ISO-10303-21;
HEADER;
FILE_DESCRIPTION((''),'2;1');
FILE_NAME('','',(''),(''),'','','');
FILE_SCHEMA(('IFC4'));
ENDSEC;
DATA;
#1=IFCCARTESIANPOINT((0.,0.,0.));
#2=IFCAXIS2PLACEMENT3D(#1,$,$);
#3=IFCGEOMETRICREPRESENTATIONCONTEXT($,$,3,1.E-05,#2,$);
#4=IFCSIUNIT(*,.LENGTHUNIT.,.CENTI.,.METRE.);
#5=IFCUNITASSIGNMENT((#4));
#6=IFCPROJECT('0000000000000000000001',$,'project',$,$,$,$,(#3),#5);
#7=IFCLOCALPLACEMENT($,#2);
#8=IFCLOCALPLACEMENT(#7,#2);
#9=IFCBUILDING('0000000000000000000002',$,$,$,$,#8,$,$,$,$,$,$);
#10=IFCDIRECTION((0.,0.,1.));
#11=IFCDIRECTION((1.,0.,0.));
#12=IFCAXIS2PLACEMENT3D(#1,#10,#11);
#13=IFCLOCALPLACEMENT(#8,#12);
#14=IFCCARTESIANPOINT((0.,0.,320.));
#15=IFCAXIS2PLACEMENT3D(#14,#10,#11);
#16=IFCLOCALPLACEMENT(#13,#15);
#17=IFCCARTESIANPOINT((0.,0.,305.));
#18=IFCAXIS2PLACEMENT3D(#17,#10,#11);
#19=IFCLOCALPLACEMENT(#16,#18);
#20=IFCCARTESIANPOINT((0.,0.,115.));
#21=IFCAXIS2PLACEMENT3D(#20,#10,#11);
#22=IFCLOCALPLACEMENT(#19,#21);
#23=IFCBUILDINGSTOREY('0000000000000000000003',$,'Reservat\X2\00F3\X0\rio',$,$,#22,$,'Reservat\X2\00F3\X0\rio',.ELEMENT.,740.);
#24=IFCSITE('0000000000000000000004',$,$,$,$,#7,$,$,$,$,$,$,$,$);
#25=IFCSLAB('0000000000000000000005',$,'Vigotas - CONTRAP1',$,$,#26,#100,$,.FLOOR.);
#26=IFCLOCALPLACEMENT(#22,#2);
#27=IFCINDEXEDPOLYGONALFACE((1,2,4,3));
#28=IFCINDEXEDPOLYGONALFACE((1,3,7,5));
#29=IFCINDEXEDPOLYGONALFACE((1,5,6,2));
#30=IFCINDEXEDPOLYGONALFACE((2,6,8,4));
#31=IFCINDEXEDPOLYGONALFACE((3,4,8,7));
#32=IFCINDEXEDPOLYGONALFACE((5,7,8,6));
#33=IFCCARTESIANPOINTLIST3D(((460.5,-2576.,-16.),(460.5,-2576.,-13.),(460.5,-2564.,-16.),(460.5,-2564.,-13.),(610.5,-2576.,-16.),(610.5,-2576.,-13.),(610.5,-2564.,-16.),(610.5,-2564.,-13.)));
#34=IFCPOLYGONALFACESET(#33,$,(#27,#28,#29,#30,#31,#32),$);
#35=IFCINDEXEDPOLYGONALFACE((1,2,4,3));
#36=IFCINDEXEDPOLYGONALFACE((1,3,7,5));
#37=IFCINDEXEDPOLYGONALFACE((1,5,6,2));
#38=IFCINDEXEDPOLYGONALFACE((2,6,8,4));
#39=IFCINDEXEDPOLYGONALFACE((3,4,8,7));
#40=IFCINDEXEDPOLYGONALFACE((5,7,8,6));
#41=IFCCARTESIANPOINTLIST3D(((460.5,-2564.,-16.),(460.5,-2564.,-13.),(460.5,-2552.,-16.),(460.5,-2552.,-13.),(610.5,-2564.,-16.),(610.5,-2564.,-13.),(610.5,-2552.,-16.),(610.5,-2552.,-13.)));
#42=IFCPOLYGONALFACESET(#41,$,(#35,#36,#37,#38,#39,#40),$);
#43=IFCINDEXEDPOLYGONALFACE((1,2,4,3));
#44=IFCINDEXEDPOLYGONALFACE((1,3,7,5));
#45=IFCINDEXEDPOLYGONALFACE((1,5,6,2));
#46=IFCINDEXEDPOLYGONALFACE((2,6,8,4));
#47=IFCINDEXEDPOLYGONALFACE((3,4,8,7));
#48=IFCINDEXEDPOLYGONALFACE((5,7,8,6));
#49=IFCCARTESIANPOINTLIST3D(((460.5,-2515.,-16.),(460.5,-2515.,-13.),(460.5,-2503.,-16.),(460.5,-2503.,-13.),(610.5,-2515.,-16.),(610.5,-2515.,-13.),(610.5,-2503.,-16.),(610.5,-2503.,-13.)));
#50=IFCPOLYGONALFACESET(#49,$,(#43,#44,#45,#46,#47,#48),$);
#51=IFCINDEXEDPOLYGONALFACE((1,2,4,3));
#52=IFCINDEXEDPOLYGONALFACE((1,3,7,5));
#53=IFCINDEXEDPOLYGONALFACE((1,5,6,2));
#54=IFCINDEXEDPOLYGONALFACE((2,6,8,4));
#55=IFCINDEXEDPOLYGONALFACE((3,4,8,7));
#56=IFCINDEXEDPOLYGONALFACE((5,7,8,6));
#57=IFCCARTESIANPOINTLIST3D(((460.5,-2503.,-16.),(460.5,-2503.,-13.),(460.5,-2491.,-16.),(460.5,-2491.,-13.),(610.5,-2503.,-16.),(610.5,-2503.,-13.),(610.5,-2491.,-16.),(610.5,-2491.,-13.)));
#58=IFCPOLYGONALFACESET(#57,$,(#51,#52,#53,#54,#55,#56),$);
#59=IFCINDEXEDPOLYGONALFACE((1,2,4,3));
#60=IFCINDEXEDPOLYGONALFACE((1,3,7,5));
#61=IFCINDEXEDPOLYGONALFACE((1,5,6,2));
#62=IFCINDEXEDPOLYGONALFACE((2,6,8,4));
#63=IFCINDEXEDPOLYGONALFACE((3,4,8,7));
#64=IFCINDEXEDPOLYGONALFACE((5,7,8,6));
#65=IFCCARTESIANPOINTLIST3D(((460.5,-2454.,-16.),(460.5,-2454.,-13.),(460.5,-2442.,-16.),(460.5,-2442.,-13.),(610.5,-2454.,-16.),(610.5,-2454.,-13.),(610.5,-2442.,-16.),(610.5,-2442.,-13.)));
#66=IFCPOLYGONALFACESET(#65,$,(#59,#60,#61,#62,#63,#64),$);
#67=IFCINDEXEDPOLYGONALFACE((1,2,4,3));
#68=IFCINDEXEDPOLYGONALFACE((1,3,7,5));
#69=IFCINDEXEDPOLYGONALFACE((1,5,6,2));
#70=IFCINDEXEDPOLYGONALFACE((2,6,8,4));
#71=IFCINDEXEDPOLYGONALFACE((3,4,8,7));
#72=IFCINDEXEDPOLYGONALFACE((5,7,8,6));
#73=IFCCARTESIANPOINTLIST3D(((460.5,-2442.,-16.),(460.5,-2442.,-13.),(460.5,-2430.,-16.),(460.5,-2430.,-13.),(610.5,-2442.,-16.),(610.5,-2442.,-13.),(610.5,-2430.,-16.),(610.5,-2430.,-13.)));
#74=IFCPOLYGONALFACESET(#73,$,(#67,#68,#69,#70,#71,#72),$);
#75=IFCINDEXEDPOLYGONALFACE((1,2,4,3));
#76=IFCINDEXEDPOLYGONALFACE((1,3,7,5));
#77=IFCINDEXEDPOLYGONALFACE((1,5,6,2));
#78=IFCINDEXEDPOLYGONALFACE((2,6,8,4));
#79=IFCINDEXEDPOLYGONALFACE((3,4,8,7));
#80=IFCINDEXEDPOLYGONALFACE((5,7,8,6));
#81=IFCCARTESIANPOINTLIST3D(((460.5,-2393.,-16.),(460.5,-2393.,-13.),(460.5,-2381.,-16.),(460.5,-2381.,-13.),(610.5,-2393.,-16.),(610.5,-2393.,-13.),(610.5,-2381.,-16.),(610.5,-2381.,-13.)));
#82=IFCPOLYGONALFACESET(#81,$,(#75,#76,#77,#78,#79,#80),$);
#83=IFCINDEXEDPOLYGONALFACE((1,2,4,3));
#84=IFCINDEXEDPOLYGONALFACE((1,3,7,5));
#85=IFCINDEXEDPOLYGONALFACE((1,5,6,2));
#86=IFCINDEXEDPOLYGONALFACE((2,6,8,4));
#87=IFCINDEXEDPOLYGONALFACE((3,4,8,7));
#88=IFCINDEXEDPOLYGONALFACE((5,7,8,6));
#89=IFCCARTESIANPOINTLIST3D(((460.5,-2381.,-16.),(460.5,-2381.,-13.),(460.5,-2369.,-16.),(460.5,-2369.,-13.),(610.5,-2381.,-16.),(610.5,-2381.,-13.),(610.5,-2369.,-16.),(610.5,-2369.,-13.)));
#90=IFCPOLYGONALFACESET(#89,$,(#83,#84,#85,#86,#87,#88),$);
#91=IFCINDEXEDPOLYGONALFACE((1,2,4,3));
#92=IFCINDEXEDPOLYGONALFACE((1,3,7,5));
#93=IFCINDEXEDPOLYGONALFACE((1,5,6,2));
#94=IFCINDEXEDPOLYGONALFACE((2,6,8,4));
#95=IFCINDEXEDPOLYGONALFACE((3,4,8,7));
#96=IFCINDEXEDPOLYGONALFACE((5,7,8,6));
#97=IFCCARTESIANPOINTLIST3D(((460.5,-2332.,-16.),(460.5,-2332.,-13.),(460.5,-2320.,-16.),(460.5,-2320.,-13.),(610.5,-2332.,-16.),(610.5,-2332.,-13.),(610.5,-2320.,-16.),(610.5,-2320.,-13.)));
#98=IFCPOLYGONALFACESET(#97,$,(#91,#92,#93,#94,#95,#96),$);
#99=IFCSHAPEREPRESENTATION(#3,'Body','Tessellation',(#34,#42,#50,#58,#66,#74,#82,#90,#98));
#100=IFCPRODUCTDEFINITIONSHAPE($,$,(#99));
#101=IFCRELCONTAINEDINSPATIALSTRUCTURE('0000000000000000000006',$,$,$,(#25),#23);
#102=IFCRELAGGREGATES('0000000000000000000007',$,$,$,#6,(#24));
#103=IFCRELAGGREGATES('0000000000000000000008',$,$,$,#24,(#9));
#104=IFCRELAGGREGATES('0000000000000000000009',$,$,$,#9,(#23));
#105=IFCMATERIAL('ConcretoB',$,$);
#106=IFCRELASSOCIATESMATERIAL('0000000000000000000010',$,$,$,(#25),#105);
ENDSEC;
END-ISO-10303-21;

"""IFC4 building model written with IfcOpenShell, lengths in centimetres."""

from ifc_helpers import new_model, si_unit, frame, origin, origin_with_axes, place, context, project, spatial, polyline, outline, extrude, material, element, save


model = new_model("IFC4")

# Units and contexts
context_of_model = context(None, 3, precision=1e-05, world=origin())
ifc_project = project(units=[si_unit("LENGTHUNIT", "METRE", prefix="CENTI")], contexts=[context_of_model])

# Site, building, storey
site_placement = place(None, origin())
site = spatial("IfcSite", under=ifc_project, at=site_placement)
building_placement = place(site_placement, origin())
building = spatial("IfcBuilding", under=site, at=building_placement)
placement_1 = place(building_placement, origin_with_axes())
placement_2 = place(placement_1, frame((0.0, 0.0, 320.0), z_axis=(0.0, 0.0, 1.0), x_axis=(1.0, 0.0, 0.0)))
placement_3 = place(placement_2, frame((0.0, 0.0, 305.0), z_axis=(0.0, 0.0, 1.0), x_axis=(1.0, 0.0, 0.0)))
storey_placement = place(placement_3, frame((0.0, 0.0, 115.0), z_axis=(0.0, 0.0, 1.0), x_axis=(1.0, 0.0, 0.0)))
storey = spatial("IfcBuildingStorey", under=building, at=storey_placement, Name="Reservatório", LongName="Reservatório", CompositionType="ELEMENT", Elevation=740.0)

# Shared definitions
ifc_material = material(Name="ConcretoB")

# Slab
slab_placement = place(storey_placement, frame((535.5, -2448.0, -13.0), z_axis=(0.0, 0.0, 1.0), x_axis=(1.0, 0.0, 0.0)))
element("IfcSlab", 1, at=slab_placement, inside=storey, material=ifc_material, Name="Vigotas - CONTRAP1", PredefinedType="FLOOR", context=context_of_model, shape_type="SolidModel", body=[
    extrude(outline(polyline([(6.0, 1.5), (-6.0, 1.5), (-6.0, -1.5), (6.0, -1.5), (6.0, 1.5), (6.0, 1.5)])), frame((-75.0, -122.0, -1.5), z_axis=(1.0, 0.0, 0.0), x_axis=(0.0, -1.0, 0.0)), (0.0, 0.0, 1.0), 150.0),
    extrude(outline(polyline([(6.0, 1.5), (-6.0, 1.5), (-6.0, -1.5), (6.0, -1.5), (6.0, 1.5), (6.0, 1.5)])), frame((-75.0, -110.0, -1.5), z_axis=(1.0, 0.0, 0.0), x_axis=(0.0, -1.0, 0.0)), (0.0, 0.0, 1.0), 150.0),
    extrude(outline(polyline([(6.0, 1.5), (-6.0, 1.5), (-6.0, -1.5), (6.0, -1.5), (6.0, 1.5), (6.0, 1.5)])), frame((-75.0, -61.0, -1.5), z_axis=(1.0, 0.0, 0.0), x_axis=(0.0, -1.0, 0.0)), (0.0, 0.0, 1.0), 150.0),
    extrude(outline(polyline([(6.0, 1.5), (-6.0, 1.5), (-6.0, -1.5), (6.0, -1.5), (6.0, 1.5), (6.0, 1.5)])), frame((-75.0, -49.0, -1.5), z_axis=(1.0, 0.0, 0.0), x_axis=(0.0, -1.0, 0.0)), (0.0, 0.0, 1.0), 150.0),
    extrude(outline(polyline([(6.0, 1.5), (-6.0, 1.5), (-6.0, -1.5), (6.0, -1.5), (6.0, 1.5), (6.0, 1.5)])), frame((-75.0, 0.0, -1.5), z_axis=(1.0, 0.0, 0.0), x_axis=(0.0, -1.0, 0.0)), (0.0, 0.0, 1.0), 150.0),
    extrude(outline(polyline([(6.0, 1.5), (-6.0, 1.5), (-6.0, -1.5), (6.0, -1.5), (6.0, 1.5), (6.0, 1.5)])), frame((-75.0, 12.0, -1.5), z_axis=(1.0, 0.0, 0.0), x_axis=(0.0, -1.0, 0.0)), (0.0, 0.0, 1.0), 150.0),
    extrude(outline(polyline([(6.0, 1.5), (-6.0, 1.5), (-6.0, -1.5), (6.0, -1.5), (6.0, 1.5), (6.0, 1.5)])), frame((-75.0, 61.0, -1.5), z_axis=(1.0, 0.0, 0.0), x_axis=(0.0, -1.0, 0.0)), (0.0, 0.0, 1.0), 150.0),
    extrude(outline(polyline([(6.0, 1.5), (-6.0, 1.5), (-6.0, -1.5), (6.0, -1.5), (6.0, 1.5), (6.0, 1.5)])), frame((-75.0, 73.0, -1.5), z_axis=(1.0, 0.0, 0.0), x_axis=(0.0, -1.0, 0.0)), (0.0, 0.0, 1.0), 150.0),
    extrude(outline(polyline([(6.0, 1.5), (-6.0, 1.5), (-6.0, -1.5), (6.0, -1.5), (6.0, 1.5), (6.0, 1.5)])), frame((-75.0, 122.0, -1.5), z_axis=(1.0, 0.0, 0.0), x_axis=(0.0, -1.0, 0.0)), (0.0, 0.0, 1.0), 150.0),
])

save(model, "model.ifc")
